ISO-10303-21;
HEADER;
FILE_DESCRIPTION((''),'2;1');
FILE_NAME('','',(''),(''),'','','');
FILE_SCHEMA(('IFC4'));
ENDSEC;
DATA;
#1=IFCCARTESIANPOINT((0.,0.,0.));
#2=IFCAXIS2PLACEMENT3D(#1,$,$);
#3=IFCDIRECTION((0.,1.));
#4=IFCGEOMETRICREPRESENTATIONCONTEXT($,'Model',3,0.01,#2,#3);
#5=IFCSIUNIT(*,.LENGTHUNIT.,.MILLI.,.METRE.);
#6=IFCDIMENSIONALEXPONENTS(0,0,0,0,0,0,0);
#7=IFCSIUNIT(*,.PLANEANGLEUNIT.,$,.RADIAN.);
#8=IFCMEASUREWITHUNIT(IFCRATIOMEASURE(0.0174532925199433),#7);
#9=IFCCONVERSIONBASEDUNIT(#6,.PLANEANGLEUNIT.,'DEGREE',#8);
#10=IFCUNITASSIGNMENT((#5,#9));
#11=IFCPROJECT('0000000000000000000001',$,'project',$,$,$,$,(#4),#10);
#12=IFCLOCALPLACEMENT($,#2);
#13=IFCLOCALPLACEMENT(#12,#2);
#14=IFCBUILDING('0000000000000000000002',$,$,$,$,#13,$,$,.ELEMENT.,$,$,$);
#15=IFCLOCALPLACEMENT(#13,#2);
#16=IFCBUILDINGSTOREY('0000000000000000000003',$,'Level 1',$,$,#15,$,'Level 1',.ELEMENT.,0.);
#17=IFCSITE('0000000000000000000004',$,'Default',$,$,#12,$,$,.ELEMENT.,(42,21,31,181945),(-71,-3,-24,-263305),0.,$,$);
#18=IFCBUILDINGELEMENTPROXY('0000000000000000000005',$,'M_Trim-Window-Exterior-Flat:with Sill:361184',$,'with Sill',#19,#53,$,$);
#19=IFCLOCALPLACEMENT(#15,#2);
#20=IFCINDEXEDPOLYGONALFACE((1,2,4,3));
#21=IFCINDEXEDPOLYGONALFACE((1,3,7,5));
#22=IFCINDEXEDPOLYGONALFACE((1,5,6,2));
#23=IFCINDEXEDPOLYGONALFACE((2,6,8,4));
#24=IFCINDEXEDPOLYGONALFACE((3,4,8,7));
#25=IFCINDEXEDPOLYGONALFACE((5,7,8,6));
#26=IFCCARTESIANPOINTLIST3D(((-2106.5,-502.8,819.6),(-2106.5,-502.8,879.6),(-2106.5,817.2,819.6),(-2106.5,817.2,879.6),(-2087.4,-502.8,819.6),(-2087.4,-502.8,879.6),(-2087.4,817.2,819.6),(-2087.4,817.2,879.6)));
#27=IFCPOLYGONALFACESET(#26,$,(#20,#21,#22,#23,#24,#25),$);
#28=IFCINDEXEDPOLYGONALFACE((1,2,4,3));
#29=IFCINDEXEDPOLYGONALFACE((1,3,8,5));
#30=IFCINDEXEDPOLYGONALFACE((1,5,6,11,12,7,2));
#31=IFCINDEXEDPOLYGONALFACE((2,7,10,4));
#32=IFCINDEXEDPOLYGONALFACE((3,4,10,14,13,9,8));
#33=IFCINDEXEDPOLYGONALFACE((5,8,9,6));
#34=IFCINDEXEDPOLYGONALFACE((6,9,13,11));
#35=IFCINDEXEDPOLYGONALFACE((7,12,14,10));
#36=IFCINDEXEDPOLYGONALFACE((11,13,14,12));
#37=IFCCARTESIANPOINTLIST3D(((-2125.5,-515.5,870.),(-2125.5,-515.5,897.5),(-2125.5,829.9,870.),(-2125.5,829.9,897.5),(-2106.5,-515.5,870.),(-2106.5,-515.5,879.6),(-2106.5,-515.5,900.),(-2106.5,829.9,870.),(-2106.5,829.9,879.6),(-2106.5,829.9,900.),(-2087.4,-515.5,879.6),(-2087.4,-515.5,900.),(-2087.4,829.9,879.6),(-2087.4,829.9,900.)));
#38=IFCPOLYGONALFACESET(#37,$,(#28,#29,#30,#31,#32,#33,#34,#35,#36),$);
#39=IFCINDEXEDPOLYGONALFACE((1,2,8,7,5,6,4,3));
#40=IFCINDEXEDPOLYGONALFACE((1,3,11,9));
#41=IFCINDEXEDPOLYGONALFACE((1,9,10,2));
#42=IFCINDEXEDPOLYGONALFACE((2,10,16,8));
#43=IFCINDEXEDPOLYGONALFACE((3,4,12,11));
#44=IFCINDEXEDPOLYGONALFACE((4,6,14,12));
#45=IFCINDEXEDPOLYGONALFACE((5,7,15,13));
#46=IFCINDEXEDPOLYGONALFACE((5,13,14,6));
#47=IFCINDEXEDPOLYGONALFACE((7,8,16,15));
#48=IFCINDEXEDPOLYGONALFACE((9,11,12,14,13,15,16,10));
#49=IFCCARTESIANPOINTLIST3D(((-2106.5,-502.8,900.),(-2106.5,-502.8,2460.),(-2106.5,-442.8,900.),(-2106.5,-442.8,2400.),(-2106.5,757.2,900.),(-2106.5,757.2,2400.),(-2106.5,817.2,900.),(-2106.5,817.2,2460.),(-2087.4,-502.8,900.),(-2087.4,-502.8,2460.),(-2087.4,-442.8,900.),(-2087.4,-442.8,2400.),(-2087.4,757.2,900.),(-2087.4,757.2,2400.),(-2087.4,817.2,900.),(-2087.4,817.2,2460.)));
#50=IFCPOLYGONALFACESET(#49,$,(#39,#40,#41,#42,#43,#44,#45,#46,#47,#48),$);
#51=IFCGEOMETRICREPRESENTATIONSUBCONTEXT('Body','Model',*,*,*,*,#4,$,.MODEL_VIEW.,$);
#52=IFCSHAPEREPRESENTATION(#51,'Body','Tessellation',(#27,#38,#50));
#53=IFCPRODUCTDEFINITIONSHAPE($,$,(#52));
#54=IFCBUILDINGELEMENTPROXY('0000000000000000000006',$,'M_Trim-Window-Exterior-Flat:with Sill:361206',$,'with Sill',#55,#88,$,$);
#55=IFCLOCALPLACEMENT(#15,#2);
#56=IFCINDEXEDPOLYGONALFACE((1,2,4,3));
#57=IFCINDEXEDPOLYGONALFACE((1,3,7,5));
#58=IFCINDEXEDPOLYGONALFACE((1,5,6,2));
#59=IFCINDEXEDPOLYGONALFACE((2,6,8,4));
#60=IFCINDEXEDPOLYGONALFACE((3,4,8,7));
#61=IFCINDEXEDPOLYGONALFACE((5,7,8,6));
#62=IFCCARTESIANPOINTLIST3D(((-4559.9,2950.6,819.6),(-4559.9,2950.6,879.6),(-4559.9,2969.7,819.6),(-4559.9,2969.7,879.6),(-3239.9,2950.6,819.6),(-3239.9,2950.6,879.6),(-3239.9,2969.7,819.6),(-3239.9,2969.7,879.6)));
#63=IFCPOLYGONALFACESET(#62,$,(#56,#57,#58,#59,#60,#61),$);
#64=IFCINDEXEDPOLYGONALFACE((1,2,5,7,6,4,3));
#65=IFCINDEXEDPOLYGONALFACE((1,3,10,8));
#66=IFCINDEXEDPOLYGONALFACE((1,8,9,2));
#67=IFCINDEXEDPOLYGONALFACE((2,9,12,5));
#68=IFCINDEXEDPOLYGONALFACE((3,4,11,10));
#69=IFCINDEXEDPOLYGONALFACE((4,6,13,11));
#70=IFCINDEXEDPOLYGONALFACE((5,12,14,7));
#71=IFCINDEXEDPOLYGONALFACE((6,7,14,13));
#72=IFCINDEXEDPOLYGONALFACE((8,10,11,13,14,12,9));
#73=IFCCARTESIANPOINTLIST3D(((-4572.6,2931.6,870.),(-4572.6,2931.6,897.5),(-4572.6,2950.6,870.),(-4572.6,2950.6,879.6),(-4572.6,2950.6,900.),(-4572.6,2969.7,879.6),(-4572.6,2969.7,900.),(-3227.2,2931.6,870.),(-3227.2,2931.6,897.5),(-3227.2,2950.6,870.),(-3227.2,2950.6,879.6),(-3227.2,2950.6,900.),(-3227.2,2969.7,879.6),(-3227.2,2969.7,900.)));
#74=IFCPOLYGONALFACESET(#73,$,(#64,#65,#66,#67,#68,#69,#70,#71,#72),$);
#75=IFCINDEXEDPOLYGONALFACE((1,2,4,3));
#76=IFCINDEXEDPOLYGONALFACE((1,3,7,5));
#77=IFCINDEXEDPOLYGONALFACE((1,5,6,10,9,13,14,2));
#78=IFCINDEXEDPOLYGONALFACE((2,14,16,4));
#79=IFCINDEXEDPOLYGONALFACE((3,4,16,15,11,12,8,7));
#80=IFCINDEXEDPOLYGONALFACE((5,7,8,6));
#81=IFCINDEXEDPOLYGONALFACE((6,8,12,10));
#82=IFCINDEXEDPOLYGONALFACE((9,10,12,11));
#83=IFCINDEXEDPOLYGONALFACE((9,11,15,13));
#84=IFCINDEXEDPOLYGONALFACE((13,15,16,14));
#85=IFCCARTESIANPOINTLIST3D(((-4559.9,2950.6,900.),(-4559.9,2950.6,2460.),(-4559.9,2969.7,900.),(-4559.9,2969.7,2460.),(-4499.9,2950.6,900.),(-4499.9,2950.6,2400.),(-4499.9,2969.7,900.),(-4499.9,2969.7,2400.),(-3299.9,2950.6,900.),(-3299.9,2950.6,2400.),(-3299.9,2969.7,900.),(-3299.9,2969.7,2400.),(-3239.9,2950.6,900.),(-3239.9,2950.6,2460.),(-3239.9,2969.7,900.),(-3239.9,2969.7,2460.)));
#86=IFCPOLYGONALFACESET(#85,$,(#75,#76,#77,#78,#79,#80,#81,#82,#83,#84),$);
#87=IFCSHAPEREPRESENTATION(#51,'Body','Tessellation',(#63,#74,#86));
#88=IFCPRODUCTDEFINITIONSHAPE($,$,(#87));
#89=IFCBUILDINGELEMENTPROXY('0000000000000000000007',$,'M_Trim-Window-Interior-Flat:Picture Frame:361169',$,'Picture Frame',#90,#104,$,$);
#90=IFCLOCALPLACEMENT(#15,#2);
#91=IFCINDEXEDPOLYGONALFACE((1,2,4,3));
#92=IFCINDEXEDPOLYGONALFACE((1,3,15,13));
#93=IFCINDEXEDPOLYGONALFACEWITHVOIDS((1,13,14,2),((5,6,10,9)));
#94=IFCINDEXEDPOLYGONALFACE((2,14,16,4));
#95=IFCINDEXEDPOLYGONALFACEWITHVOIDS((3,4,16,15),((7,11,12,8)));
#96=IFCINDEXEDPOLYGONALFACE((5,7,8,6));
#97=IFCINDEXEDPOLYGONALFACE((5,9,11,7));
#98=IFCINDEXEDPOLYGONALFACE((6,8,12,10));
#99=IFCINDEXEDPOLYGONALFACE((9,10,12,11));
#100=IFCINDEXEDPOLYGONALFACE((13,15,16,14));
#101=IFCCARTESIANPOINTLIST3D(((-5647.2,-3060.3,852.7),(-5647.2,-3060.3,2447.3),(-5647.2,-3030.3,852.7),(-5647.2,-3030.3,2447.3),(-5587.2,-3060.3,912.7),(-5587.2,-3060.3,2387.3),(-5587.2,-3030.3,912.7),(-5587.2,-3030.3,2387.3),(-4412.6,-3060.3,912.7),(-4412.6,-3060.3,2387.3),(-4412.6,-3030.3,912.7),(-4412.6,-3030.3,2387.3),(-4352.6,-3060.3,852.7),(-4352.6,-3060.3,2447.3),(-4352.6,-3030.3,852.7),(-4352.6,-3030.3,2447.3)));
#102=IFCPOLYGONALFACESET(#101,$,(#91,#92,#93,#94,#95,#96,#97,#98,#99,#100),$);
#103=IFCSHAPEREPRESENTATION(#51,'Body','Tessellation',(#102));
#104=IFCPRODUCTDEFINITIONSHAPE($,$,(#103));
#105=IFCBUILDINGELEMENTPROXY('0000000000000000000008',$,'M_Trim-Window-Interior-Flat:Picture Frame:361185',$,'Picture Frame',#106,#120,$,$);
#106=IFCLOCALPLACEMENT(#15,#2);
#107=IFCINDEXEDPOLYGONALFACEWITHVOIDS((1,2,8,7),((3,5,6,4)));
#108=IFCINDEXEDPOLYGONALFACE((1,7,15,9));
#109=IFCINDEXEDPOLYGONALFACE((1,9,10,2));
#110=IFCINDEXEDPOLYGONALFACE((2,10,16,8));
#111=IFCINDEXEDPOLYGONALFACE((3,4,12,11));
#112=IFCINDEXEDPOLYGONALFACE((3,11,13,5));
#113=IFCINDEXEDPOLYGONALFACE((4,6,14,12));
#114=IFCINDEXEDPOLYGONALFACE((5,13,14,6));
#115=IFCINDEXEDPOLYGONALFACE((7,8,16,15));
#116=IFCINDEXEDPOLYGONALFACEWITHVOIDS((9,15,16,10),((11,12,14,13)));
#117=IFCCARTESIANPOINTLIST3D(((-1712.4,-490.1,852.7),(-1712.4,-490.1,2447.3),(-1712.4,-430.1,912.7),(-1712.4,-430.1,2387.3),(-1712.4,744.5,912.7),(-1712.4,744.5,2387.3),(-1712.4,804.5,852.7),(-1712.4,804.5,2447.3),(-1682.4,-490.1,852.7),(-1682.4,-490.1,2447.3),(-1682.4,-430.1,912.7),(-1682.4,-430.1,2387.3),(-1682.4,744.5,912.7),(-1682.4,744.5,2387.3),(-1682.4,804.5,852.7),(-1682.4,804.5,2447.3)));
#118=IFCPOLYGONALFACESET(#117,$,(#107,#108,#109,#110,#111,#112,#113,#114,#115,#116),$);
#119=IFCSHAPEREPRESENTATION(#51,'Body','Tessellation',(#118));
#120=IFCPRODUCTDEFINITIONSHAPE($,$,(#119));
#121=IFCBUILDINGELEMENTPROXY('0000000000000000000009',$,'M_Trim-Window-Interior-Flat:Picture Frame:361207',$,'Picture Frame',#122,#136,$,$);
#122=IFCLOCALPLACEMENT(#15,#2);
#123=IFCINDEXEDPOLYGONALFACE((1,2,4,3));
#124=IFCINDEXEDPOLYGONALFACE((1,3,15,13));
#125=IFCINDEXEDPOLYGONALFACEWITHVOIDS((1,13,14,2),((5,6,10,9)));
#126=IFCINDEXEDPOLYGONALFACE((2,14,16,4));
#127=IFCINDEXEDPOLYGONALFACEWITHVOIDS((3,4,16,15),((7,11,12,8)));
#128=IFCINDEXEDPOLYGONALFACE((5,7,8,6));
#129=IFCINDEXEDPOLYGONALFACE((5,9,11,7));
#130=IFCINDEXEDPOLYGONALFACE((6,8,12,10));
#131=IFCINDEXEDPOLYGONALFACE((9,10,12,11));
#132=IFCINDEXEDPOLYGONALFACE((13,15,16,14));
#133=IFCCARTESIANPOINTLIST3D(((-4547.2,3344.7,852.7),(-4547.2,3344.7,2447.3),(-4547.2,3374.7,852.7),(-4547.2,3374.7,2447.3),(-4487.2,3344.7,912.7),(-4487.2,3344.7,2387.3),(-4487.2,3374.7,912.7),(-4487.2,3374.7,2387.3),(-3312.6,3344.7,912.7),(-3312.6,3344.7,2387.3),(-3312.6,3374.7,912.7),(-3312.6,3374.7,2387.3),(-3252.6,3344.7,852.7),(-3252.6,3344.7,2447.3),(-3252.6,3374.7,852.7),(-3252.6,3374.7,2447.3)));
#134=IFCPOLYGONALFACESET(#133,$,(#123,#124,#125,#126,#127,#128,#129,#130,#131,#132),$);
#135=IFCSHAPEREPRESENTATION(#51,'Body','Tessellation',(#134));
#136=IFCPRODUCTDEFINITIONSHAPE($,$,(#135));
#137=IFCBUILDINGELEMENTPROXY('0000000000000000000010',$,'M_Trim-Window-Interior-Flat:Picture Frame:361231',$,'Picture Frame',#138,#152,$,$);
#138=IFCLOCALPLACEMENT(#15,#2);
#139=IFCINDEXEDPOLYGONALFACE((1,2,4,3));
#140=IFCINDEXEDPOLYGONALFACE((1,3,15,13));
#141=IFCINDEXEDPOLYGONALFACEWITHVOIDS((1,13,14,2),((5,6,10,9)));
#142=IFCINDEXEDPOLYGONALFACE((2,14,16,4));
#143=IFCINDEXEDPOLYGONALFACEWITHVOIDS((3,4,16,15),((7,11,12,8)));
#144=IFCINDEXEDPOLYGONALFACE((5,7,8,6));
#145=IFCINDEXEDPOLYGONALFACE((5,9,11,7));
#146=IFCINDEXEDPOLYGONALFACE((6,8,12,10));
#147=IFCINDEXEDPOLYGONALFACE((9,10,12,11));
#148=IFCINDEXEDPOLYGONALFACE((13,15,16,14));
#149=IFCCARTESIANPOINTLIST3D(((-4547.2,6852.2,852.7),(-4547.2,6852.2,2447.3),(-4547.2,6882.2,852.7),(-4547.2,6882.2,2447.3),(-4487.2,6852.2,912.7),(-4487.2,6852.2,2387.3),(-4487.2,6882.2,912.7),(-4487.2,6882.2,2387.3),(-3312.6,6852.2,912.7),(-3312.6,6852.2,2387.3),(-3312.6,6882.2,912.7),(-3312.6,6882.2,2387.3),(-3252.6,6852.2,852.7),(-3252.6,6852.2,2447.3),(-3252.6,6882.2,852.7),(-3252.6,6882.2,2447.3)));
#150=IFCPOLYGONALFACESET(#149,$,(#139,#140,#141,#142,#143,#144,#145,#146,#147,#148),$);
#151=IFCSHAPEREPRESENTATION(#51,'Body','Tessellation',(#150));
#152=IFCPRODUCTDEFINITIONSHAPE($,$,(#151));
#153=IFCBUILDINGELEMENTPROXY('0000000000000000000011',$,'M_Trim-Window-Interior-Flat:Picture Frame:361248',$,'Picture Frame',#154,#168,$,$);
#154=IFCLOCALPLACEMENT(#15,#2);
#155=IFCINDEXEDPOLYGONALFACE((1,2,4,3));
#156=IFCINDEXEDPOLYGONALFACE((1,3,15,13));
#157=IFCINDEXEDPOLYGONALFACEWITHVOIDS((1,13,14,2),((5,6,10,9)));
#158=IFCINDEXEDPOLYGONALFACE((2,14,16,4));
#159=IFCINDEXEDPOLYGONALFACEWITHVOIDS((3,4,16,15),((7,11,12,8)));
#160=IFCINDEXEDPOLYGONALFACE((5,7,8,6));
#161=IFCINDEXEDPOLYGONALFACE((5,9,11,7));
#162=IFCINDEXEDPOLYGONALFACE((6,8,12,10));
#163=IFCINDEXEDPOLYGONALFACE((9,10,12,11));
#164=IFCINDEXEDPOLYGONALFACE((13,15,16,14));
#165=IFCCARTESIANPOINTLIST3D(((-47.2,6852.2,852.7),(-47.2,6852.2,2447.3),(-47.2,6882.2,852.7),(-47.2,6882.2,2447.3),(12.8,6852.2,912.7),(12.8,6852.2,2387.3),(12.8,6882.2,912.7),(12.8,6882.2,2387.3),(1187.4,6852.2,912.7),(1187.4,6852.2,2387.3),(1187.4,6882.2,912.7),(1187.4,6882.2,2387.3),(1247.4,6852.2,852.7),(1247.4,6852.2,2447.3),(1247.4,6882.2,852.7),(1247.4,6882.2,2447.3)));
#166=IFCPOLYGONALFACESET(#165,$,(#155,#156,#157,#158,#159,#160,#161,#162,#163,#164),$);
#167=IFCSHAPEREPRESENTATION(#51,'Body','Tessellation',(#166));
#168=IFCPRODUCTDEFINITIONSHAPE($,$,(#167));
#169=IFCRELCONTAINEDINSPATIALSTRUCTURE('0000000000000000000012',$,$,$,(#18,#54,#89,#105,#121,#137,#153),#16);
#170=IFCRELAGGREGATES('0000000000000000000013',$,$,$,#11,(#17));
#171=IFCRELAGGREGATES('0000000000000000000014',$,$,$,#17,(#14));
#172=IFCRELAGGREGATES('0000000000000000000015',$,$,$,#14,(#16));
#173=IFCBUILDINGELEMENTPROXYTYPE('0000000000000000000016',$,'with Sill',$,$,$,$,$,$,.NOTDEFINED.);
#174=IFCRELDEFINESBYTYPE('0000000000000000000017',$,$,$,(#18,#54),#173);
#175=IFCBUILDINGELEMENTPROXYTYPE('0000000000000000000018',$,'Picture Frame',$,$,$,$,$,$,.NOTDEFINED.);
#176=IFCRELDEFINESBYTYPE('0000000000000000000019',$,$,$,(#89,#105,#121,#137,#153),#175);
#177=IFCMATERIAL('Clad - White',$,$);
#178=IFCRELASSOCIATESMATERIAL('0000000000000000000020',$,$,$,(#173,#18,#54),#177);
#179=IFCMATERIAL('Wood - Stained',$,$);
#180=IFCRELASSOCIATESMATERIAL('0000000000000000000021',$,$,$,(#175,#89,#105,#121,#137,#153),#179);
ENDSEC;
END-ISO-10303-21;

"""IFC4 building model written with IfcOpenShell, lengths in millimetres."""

from ifc_helpers import new_model, entity, si_unit, converted_unit, direction, frame, frame_2d, origin, place, context, subcontext, project, spatial, polyline, rectangle, outline, extrude, source, transform, mapped, material, type_object, type_shapes, element, save


model = new_model("IFC4")

# Units and contexts
model_context = context("Model", 3, precision=0.01, world=origin(), true_north=direction((0.0, 1.0)))
body_context = subcontext(model_context, "Body", "Model", "MODEL_VIEW")
ifc_project = project(units=[si_unit("LENGTHUNIT", "METRE", prefix="MILLI"), converted_unit("PLANEANGLEUNIT", "DEGREE", entity("IfcRatioMeasure", 0.0174532925199433), si_unit("PLANEANGLEUNIT", "RADIAN"), dimensions=[0, 0, 0, 0, 0, 0, 0])], contexts=[model_context])

# Site, building, storey
site_placement = place(None, origin())
site = spatial("IfcSite", under=ifc_project, at=site_placement, Name="Default", CompositionType="ELEMENT", RefLatitude=(42, 21, 31, 181945), RefLongitude=(-71, -3, -24, -263305), RefElevation=0.0)
building_placement = place(site_placement, origin())
building = spatial("IfcBuilding", under=site, at=building_placement, CompositionType="ELEMENT")
storey_placement = place(building_placement, origin())
storey = spatial("IfcBuildingStorey", under=building, at=storey_placement, Name="Level 1", LongName="Level 1", CompositionType="ELEMENT", Elevation=0.0)

# Building element proxies
ifc_material_1 = material(Name="Clad - White")
ifc_material_2 = material(Name="Wood - Stained")
building_element_proxy_type_1 = type_object("IfcBuildingElementProxyType", Name="with Sill", PredefinedType="NOTDEFINED", material=ifc_material_1)
shared_shape_1 = source(origin(), body_context, "Body", "SweptSolid", [
    extrude(rectangle(XDim=1320.0, YDim=60.0, at=frame_2d((0.0, 0.0), x_axis=(1.0, 0.0))), frame((0.0, -1550.4, 0.0), z_axis=(0.0, 0.0, 1.0), x_axis=(-1.0, 0.0, 0.0)), (0.0, 0.0, 1.0), 19.1),
    extrude(outline(polyline([(-19.0, -15.2), (0.0, -15.2), (0.0, -5.7), (19.0, -5.7), (19.0, 14.8), (0.0, 14.8), (-19.0, 12.3), (-19.0, -15.2)])), frame((-672.7, -1514.8, 19.0), z_axis=(1.0, 0.0, 0.0), x_axis=(0.0, 0.0, -1.0)), (0.0, 0.0, 1.0), 1345.4),
    extrude(outline(polyline([(-795.0, -660.0), (765.0, -660.0), (765.0, -600.0), (-735.0, -600.0), (-735.0, 600.0), (765.0, 600.0), (765.0, 660.0), (-795.0, 660.0), (-795.0, -660.0)])), frame((0.0, -735.0, 0.0), z_axis=(0.0, 0.0, 1.0), x_axis=(0.0, -1.0, 0.0)), (0.0, 0.0, 1.0), 19.1),
])
type_shapes(building_element_proxy_type_1, [shared_shape_1])
for number, where, z_axis, x_axis, name in (
    (1, (-2087.4, 157.2, 2400.0), (-1.0, 0.0, 0.0), (0.0, -1.0, 0.0), "M_Trim-Window-Exterior-Flat:with Sill:361184"),
    (2, (-3899.9, 2969.7, 2400.0), (0.0, -1.0, 0.0), (1.0, 0.0, 0.0), "M_Trim-Window-Exterior-Flat:with Sill:361206"),
):
    element("IfcBuildingElementProxy", number, at=place(storey_placement, frame(where, z_axis=z_axis, x_axis=x_axis)), inside=storey, type_object=building_element_proxy_type_1, material=ifc_material_1, Name=name, ObjectType="with Sill", context=body_context, shape_type="MappedRepresentation", body=[
        mapped(shared_shape_1, transform((0.0, 0.0, 0.0), scale=1.0)),
    ])
building_element_proxy_type_2 = type_object("IfcBuildingElementProxyType", Name="Picture Frame", PredefinedType="NOTDEFINED", material=ifc_material_2)
shared_shape_2 = source(origin(), body_context, "Body", "SweptSolid", [
    extrude(outline(polyline([(-647.3, -797.3), (647.3, -797.3), (647.3, 797.3), (-647.3, 797.3), (-647.3, -797.3)]), holes=[polyline([(-587.3, -737.3), (-587.3, 737.3), (587.3, 737.3), (587.3, -737.3), (-587.3, -737.3)])]), frame((0.0, -750.0, 0.0), z_axis=(0.0, 0.0, 1.0), x_axis=(-1.0, 0.0, 0.0)), (0.0, 0.0, 1.0), 30.0),
])
type_shapes(building_element_proxy_type_2, [shared_shape_2])
for number, where, z_axis, x_axis, name in (
    (3, (-4999.9, -3030.3, 2400.0), (0.0, -1.0, 0.0), (1.0, 0.0, 0.0), "M_Trim-Window-Interior-Flat:Picture Frame:361169"),
    (4, (-1712.4, 157.2, 2400.0), (1.0, 0.0, 0.0), (0.0, 1.0, 0.0), "M_Trim-Window-Interior-Flat:Picture Frame:361185"),
    (5, (-3899.9, 3344.7, 2400.0), (0.0, 1.0, 0.0), (-1.0, 0.0, 0.0), "M_Trim-Window-Interior-Flat:Picture Frame:361207"),
    (6, (-3899.9, 6882.2, 2400.0), (0.0, -1.0, 0.0), (1.0, 0.0, 0.0), "M_Trim-Window-Interior-Flat:Picture Frame:361231"),
    (7, (600.1, 6882.2, 2400.0), (0.0, -1.0, 0.0), (1.0, 0.0, 0.0), "M_Trim-Window-Interior-Flat:Picture Frame:361248"),
):
    element("IfcBuildingElementProxy", number, at=place(storey_placement, frame(where, z_axis=z_axis, x_axis=x_axis)), inside=storey, type_object=building_element_proxy_type_2, material=ifc_material_2, Name=name, ObjectType="Picture Frame", context=body_context, shape_type="MappedRepresentation", body=[
        mapped(shared_shape_2, transform((0.0, 0.0, 0.0), scale=1.0)),
    ])

save(model, "model.ifc")
